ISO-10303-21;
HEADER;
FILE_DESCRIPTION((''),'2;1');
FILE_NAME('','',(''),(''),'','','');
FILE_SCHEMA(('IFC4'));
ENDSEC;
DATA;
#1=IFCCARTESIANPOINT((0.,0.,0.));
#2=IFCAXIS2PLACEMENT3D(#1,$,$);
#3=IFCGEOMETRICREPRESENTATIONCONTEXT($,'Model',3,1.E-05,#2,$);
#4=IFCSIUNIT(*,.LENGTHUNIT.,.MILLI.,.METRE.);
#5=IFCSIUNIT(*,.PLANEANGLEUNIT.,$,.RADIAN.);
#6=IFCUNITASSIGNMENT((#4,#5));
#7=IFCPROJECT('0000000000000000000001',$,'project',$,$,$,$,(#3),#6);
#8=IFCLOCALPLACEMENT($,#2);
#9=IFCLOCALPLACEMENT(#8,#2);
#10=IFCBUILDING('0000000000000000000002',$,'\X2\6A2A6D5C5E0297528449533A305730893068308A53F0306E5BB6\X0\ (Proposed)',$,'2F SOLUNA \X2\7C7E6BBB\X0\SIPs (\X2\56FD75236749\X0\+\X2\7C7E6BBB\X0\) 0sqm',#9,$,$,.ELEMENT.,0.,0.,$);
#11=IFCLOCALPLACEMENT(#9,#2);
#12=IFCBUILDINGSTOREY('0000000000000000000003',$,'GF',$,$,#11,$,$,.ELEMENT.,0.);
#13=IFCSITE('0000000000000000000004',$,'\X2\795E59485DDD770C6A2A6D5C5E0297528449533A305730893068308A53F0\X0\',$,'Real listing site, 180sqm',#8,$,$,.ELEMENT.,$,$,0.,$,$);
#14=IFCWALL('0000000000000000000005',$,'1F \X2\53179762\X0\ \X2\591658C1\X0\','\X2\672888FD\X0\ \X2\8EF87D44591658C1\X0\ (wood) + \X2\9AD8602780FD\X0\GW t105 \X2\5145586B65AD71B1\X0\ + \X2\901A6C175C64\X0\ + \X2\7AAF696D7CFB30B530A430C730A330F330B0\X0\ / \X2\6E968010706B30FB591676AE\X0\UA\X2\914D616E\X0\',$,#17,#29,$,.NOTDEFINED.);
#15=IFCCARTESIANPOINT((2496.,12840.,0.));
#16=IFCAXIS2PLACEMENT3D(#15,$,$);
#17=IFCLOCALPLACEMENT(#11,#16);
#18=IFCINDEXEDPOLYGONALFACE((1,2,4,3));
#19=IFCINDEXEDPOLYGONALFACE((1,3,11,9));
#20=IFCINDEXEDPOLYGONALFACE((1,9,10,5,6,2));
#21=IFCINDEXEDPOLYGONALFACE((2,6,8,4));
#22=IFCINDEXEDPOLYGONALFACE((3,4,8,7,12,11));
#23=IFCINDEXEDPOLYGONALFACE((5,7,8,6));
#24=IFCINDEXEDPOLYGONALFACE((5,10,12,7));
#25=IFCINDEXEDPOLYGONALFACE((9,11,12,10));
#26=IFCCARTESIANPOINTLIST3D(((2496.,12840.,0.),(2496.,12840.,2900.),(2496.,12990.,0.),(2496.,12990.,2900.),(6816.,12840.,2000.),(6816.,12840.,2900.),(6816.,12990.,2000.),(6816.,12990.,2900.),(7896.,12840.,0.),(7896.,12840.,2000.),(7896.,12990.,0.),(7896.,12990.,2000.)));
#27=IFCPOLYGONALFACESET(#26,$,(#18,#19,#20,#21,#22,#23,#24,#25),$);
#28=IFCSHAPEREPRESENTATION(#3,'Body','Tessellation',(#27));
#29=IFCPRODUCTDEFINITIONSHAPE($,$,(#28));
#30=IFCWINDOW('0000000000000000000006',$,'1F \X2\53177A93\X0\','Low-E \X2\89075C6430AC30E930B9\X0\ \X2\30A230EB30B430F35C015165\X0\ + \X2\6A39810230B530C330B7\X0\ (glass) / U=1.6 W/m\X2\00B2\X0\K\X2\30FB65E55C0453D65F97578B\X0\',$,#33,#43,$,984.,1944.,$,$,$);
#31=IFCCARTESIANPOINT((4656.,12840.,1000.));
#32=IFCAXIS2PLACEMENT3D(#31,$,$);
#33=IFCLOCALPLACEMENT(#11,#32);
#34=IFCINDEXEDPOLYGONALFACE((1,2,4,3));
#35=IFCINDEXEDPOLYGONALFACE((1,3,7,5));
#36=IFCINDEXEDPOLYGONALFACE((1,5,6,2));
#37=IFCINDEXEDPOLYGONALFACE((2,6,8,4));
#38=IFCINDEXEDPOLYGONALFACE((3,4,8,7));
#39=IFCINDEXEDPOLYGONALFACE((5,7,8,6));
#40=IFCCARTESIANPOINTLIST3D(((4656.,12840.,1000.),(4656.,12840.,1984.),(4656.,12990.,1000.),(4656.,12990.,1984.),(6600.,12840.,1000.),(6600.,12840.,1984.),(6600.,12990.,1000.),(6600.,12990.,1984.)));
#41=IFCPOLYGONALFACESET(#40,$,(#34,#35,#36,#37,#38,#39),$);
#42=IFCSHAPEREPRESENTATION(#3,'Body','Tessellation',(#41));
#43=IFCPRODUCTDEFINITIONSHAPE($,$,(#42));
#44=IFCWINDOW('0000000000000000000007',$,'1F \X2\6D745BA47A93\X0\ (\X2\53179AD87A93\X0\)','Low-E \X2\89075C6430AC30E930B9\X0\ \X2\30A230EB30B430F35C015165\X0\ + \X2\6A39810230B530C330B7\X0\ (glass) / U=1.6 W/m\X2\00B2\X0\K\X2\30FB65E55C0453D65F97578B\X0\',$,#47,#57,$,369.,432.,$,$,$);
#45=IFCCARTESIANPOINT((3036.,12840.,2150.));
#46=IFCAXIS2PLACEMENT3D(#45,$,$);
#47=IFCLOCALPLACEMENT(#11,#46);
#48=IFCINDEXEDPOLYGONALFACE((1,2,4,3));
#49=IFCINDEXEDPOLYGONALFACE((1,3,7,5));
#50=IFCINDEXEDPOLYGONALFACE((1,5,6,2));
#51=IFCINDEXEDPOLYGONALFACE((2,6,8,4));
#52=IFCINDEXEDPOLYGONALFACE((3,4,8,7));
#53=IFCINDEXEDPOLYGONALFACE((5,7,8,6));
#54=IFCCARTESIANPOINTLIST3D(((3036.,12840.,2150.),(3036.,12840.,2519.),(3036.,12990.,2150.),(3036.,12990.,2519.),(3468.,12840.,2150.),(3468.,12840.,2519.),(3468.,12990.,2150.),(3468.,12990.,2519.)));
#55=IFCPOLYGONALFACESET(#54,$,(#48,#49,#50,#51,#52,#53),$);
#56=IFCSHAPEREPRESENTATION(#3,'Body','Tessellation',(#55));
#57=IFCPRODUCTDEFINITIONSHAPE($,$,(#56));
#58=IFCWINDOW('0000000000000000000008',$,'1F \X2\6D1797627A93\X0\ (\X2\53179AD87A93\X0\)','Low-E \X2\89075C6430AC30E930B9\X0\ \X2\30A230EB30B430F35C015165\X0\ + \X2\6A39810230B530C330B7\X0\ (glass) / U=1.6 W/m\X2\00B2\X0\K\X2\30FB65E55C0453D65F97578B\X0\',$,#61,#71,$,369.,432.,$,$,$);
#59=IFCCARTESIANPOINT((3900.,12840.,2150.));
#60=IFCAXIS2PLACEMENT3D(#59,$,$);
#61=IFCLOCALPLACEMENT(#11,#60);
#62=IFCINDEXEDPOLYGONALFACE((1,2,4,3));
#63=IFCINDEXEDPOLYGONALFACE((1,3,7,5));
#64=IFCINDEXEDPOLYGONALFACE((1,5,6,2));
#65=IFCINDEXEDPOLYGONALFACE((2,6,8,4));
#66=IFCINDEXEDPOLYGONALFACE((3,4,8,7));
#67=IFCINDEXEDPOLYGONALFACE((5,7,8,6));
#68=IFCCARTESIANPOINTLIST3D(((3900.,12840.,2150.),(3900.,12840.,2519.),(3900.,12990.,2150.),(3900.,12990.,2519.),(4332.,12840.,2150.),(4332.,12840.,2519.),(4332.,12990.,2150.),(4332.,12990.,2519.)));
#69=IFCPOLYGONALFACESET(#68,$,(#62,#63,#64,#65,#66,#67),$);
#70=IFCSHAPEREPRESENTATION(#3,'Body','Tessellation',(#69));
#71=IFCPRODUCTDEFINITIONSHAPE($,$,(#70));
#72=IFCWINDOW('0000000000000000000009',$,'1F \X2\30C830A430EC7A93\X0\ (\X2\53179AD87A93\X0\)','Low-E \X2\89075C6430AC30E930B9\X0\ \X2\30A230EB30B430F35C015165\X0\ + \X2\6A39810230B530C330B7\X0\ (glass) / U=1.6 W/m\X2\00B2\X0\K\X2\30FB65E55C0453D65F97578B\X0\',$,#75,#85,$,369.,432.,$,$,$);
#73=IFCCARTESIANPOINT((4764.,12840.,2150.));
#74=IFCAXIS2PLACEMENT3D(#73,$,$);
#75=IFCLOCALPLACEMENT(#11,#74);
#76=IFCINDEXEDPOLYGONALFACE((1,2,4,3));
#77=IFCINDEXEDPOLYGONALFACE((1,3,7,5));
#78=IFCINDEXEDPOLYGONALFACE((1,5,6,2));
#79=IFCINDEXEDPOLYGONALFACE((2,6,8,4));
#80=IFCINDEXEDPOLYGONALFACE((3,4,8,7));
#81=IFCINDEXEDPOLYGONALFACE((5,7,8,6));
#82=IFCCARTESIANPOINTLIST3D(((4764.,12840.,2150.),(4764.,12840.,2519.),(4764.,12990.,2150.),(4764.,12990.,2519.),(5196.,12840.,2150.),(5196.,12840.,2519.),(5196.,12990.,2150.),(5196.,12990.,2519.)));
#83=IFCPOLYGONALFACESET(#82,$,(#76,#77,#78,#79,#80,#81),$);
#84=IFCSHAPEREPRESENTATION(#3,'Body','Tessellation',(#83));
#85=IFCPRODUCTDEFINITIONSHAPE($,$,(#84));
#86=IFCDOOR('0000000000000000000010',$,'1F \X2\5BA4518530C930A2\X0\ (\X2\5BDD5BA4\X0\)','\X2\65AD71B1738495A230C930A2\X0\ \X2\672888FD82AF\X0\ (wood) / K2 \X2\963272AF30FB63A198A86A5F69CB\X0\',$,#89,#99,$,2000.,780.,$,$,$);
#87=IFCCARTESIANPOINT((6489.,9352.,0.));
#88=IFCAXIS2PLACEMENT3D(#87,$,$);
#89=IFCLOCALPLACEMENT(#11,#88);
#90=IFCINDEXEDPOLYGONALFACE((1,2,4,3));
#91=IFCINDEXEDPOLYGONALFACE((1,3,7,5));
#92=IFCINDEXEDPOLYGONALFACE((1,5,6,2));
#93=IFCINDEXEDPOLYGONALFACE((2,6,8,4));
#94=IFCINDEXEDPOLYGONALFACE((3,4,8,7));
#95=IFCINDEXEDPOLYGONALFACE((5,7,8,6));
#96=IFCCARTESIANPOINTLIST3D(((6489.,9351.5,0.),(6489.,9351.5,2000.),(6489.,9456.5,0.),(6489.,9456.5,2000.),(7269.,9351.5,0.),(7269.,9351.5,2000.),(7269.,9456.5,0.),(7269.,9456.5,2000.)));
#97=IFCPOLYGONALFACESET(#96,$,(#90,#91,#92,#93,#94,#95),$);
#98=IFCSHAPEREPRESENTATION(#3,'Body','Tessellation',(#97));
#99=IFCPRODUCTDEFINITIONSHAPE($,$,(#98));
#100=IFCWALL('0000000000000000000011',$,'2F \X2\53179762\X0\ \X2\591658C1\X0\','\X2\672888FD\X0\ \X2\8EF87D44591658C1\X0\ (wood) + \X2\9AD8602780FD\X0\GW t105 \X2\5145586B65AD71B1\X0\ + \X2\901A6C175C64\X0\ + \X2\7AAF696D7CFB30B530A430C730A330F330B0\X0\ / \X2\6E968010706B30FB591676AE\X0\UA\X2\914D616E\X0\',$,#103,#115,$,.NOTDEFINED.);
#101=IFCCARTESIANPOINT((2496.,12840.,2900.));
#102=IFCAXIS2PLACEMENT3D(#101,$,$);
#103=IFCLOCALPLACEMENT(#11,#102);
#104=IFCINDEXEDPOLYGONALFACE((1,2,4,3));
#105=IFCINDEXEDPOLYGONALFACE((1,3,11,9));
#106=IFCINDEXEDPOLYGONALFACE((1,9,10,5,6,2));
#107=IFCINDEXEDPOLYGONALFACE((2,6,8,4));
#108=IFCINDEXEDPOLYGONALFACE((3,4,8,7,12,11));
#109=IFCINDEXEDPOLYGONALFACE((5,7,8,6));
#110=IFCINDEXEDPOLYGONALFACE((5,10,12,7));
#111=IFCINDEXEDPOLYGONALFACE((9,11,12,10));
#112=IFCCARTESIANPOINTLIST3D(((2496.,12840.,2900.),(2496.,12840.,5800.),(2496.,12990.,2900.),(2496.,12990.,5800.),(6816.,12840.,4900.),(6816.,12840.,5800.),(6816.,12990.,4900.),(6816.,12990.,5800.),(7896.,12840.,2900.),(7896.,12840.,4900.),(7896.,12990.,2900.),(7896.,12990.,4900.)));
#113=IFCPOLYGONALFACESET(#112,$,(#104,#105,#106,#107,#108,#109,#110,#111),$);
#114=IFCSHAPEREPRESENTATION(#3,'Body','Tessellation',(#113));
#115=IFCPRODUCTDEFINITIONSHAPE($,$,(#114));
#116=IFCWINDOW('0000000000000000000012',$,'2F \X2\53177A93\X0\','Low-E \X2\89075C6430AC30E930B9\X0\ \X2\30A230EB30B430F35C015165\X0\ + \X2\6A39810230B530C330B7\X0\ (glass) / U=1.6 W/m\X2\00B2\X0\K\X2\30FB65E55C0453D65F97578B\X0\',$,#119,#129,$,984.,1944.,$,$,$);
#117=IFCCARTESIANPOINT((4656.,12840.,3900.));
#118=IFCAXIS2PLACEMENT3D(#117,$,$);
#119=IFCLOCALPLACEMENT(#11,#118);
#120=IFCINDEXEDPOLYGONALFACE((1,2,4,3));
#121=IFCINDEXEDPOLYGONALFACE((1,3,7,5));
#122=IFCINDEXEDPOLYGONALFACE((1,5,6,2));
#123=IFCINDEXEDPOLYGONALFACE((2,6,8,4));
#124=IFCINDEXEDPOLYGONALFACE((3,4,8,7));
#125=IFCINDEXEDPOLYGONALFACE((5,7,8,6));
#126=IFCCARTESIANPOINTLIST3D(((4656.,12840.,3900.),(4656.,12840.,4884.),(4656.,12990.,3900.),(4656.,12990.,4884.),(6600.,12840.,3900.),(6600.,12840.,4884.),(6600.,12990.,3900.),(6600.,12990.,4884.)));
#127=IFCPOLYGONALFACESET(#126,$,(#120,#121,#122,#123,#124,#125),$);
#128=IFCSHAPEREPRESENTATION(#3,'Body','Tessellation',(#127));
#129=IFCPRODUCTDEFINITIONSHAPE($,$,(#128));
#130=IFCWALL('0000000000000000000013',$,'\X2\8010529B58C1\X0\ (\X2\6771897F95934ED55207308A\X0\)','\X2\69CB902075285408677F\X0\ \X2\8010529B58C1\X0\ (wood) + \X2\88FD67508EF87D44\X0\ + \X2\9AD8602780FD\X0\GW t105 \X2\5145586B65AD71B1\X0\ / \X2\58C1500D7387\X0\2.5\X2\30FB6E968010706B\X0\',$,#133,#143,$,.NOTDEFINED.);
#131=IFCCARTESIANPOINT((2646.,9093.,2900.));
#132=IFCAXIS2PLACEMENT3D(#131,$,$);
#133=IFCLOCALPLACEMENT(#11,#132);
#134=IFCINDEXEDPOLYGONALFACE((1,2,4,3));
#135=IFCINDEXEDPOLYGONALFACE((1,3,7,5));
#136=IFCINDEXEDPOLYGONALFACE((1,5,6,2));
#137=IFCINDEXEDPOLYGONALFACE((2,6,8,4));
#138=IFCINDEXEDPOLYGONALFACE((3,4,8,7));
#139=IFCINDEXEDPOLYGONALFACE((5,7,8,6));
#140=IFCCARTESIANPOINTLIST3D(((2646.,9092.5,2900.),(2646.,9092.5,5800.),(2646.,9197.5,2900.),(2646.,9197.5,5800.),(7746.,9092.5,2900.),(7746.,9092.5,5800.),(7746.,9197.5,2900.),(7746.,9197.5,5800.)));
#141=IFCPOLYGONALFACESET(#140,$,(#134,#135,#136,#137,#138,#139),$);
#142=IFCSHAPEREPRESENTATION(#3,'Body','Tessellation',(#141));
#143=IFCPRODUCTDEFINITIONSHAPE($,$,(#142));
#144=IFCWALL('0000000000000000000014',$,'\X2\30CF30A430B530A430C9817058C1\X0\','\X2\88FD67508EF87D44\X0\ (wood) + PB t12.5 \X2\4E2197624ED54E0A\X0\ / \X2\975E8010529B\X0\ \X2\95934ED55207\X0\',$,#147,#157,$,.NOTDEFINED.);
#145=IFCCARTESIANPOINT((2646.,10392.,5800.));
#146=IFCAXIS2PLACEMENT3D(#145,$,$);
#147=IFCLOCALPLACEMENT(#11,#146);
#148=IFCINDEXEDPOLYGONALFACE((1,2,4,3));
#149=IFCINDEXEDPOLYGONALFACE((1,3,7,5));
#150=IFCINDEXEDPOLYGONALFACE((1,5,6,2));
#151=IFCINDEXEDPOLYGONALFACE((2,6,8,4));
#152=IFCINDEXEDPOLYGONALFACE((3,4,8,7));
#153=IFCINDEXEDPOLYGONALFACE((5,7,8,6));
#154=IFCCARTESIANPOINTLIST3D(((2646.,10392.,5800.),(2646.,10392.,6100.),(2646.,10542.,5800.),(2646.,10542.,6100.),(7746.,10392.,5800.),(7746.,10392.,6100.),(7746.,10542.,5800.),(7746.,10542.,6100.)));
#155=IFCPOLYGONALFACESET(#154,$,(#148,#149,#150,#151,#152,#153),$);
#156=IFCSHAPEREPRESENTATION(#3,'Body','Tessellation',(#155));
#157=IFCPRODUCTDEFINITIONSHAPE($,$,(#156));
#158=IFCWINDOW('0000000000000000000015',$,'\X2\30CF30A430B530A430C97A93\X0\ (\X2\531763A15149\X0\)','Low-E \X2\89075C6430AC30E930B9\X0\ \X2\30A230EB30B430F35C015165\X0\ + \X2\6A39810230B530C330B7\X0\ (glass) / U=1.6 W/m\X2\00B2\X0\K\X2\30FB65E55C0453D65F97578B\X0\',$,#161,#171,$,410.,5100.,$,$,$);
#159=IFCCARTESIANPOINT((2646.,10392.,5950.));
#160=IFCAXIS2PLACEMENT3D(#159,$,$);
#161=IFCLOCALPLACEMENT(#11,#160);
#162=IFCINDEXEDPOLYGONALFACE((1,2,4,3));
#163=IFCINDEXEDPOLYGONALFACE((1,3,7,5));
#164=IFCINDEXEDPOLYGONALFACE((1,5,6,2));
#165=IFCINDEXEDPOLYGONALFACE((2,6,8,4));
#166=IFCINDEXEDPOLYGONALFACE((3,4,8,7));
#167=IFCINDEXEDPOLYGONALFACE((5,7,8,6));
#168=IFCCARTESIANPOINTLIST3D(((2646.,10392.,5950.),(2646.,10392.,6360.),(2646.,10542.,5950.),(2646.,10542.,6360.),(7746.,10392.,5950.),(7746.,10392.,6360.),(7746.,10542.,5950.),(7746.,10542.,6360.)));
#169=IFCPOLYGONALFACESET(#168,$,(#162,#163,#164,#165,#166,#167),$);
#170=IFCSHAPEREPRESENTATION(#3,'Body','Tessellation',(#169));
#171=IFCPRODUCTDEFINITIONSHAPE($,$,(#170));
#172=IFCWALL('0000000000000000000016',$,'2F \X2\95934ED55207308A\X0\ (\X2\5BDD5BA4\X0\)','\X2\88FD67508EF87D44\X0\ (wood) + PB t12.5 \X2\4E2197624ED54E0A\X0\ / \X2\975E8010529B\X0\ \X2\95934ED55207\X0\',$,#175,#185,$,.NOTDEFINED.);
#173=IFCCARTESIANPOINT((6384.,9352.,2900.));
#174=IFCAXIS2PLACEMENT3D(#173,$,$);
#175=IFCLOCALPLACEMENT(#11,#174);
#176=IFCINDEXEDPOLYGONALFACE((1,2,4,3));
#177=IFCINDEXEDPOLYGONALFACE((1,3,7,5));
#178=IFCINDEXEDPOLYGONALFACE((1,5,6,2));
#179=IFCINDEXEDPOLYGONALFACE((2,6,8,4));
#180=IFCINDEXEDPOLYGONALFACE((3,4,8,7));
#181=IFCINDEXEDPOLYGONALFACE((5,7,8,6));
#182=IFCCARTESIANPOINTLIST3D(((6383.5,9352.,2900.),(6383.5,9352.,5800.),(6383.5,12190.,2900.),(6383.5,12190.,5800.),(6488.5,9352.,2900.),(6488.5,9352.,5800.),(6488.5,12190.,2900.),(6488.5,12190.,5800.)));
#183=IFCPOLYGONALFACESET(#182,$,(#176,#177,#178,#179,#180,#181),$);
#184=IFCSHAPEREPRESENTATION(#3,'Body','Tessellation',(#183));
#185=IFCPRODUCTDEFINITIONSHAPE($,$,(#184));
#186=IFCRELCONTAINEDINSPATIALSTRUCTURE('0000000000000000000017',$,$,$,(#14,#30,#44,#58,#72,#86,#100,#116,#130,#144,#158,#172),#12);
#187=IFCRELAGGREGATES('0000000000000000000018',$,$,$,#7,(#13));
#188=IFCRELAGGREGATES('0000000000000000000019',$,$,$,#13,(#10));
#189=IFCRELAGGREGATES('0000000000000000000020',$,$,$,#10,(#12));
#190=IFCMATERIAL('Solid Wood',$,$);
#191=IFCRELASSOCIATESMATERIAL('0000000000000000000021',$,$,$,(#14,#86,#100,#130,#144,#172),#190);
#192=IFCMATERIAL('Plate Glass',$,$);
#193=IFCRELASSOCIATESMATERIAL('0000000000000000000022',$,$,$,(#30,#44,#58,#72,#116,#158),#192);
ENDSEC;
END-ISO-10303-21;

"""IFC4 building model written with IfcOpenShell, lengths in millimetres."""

from ifc_helpers import new_model, si_unit, frame, frame_2d, origin, place, context, project, spatial, rectangle, extrude, material, element, fill, save


model = new_model("IFC4")

# Units and contexts
model_context = context("Model", 3, precision=1e-05, world=origin())
ifc_project = project(units=[si_unit("LENGTHUNIT", "METRE", prefix="MILLI"), si_unit("PLANEANGLEUNIT", "RADIAN")], contexts=[model_context])

# Site, building, storey
site_placement = place(None, origin())
site = spatial("IfcSite", under=ifc_project, at=site_placement, Name="神奈川県横浜市青葉区しらとり台", ObjectType="Real listing site, 180sqm", CompositionType="ELEMENT", RefElevation=0.0)
building_placement = place(site_placement, origin())
building = spatial("IfcBuilding", under=site, at=building_placement, Name="横浜市青葉区しらとり台の家 (Proposed)", ObjectType="2F SOLUNA 籾殻SIPs (国産杉+籾殻) 0sqm", CompositionType="ELEMENT", ElevationOfRefHeight=0.0, ElevationOfTerrain=0.0)
storey_placement = place(building_placement, origin())
storey = spatial("IfcBuildingStorey", under=building, at=storey_placement, Name="GF", CompositionType="ELEMENT", Elevation=0.0)

# Wall, openings, windows
ifc_material_1 = material(Name="Solid Wood")
wall_1_placement = place(storey_placement, frame((2496.0, 12840.0, 0.0)))
wall_1 = element("IfcWall", 1, at=wall_1_placement, inside=storey, material=ifc_material_1, Name="1F 北面 外壁", Description="木製 軸組外壁 (wood) + 高性能GW t105 充填断熱 + 通気層 + 窯業系サイディング / 準耐火・外皮UA配慮", PredefinedType="NOTDEFINED", context=model_context, shape_type="SweptSolid", body=[
    extrude(rectangle(XDim=5400.0, YDim=150.0, at=frame_2d((2700.0, 75.0))), frame((2496.0, 12840.0, 0.0)), (0.0, 0.0, 1.0), 2900.0),
])
opening_1_placement = place(storey_placement, frame((4656.0, 12840.0, 1000.0)))
opening_1 = element("IfcOpeningElement", 2, at=opening_1_placement, cuts=wall_1, PredefinedType="NOTDEFINED", context=model_context, shape_type="SweptSolid", body=[
    extrude(rectangle(XDim=1944.0, YDim=150.0, at=frame_2d((972.0, 75.0))), frame((4656.0, 12840.0, 1000.0)), (0.0, 0.0, 1.0), 984.0),
])
opening_2_placement = place(storey_placement, frame((3036.0, 12840.0, 2150.0)))
opening_2 = element("IfcOpeningElement", 3, at=opening_2_placement, cuts=wall_1, PredefinedType="NOTDEFINED", context=model_context, shape_type="SweptSolid", body=[
    extrude(rectangle(XDim=432.0, YDim=150.0, at=frame_2d((216.0, 75.0))), frame((3036.0, 12840.0, 2150.0)), (0.0, 0.0, 1.0), 369.0),
])
opening_3_placement = place(storey_placement, frame((3900.0, 12840.0, 2150.0)))
opening_3 = element("IfcOpeningElement", 4, at=opening_3_placement, cuts=wall_1, PredefinedType="NOTDEFINED", context=model_context, shape_type="SweptSolid", body=[
    extrude(rectangle(XDim=432.0, YDim=150.0, at=frame_2d((216.0, 75.0))), frame((3900.0, 12840.0, 2150.0)), (0.0, 0.0, 1.0), 369.0),
])
opening_4_placement = place(storey_placement, frame((4764.0, 12840.0, 2150.0)))
opening_4 = element("IfcOpeningElement", 5, at=opening_4_placement, cuts=wall_1, PredefinedType="NOTDEFINED", context=model_context, shape_type="SweptSolid", body=[
    extrude(rectangle(XDim=432.0, YDim=150.0, at=frame_2d((216.0, 75.0))), frame((4764.0, 12840.0, 2150.0)), (0.0, 0.0, 1.0), 369.0),
])
ifc_material_2 = material(Name="Plate Glass")
window_1_placement = place(storey_placement, frame((4656.0, 12840.0, 1000.0)))
window_1 = element("IfcWindow", 6, at=window_1_placement, inside=storey, material=ifc_material_2, Name="1F 北窓", Description="Low-E 複層ガラス アルゴン封入 + 樹脂サッシ (glass) / U=1.6 W/m²K・日射取得型", OverallHeight=984.0, OverallWidth=1944.0, context=model_context, shape_type="SweptSolid", body=[
    extrude(rectangle(XDim=1944.0, YDim=150.0, at=frame_2d((972.0, 75.0))), frame((4656.0, 12840.0, 1000.0)), (0.0, 0.0, 1.0), 984.0),
])
fill(opening_1, window_1)
window_2_placement = place(storey_placement, frame((3036.0, 12840.0, 2150.0)))
window_2 = element("IfcWindow", 7, at=window_2_placement, inside=storey, material=ifc_material_2, Name="1F 浴室窓 (北高窓)", Description="Low-E 複層ガラス アルゴン封入 + 樹脂サッシ (glass) / U=1.6 W/m²K・日射取得型", OverallHeight=369.0, OverallWidth=432.0, context=model_context, shape_type="SweptSolid", body=[
    extrude(rectangle(XDim=432.0, YDim=150.0, at=frame_2d((216.0, 75.0))), frame((3036.0, 12840.0, 2150.0)), (0.0, 0.0, 1.0), 369.0),
])
fill(opening_2, window_2)
window_3_placement = place(storey_placement, frame((3900.0, 12840.0, 2150.0)))
window_3 = element("IfcWindow", 8, at=window_3_placement, inside=storey, material=ifc_material_2, Name="1F 洗面窓 (北高窓)", Description="Low-E 複層ガラス アルゴン封入 + 樹脂サッシ (glass) / U=1.6 W/m²K・日射取得型", OverallHeight=369.0, OverallWidth=432.0, context=model_context, shape_type="SweptSolid", body=[
    extrude(rectangle(XDim=432.0, YDim=150.0, at=frame_2d((216.0, 75.0))), frame((3900.0, 12840.0, 2150.0)), (0.0, 0.0, 1.0), 369.0),
])
fill(opening_3, window_3)
window_4_placement = place(storey_placement, frame((4764.0, 12840.0, 2150.0)))
window_4 = element("IfcWindow", 9, at=window_4_placement, inside=storey, material=ifc_material_2, Name="1F トイレ窓 (北高窓)", Description="Low-E 複層ガラス アルゴン封入 + 樹脂サッシ (glass) / U=1.6 W/m²K・日射取得型", OverallHeight=369.0, OverallWidth=432.0, context=model_context, shape_type="SweptSolid", body=[
    extrude(rectangle(XDim=432.0, YDim=150.0, at=frame_2d((216.0, 75.0))), frame((4764.0, 12840.0, 2150.0)), (0.0, 0.0, 1.0), 369.0),
])
fill(opening_4, window_4)

# Door
door_1_placement = place(storey_placement, frame((6489.0, 9352.0, 0.0)))
element("IfcDoor", 10, at=door_1_placement, inside=storey, material=ifc_material_1, Name="1F 室内ドア (寝室)", Description="断熱玄関ドア 木製芯 (wood) / K2 防犯・採風機構", OverallHeight=2000.0, OverallWidth=780.0, context=model_context, shape_type="SweptSolid", body=[
    extrude(rectangle(XDim=780.0, YDim=105.0, at=frame_2d((390.0, 52.0))), frame((6489.0, 9352.0, 0.0)), (0.0, 0.0, 1.0), 2000.0),
])

# Wall, opening, window
wall_2_placement = place(storey_placement, frame((2496.0, 12840.0, 2900.0)))
wall_2 = element("IfcWall", 11, at=wall_2_placement, inside=storey, material=ifc_material_1, Name="2F 北面 外壁", Description="木製 軸組外壁 (wood) + 高性能GW t105 充填断熱 + 通気層 + 窯業系サイディング / 準耐火・外皮UA配慮", PredefinedType="NOTDEFINED", context=model_context, shape_type="SweptSolid", body=[
    extrude(rectangle(XDim=5400.0, YDim=150.0, at=frame_2d((2700.0, 75.0))), frame((2496.0, 12840.0, 2900.0)), (0.0, 0.0, 1.0), 2900.0),
])
opening_5_placement = place(storey_placement, frame((4656.0, 12840.0, 3900.0)))
opening_5 = element("IfcOpeningElement", 12, at=opening_5_placement, cuts=wall_2, PredefinedType="NOTDEFINED", context=model_context, shape_type="SweptSolid", body=[
    extrude(rectangle(XDim=1944.0, YDim=150.0, at=frame_2d((972.0, 75.0))), frame((4656.0, 12840.0, 3900.0)), (0.0, 0.0, 1.0), 984.0),
])
window_5_placement = place(storey_placement, frame((4656.0, 12840.0, 3900.0)))
window_5 = element("IfcWindow", 13, at=window_5_placement, inside=storey, material=ifc_material_2, Name="2F 北窓", Description="Low-E 複層ガラス アルゴン封入 + 樹脂サッシ (glass) / U=1.6 W/m²K・日射取得型", OverallHeight=984.0, OverallWidth=1944.0, context=model_context, shape_type="SweptSolid", body=[
    extrude(rectangle(XDim=1944.0, YDim=150.0, at=frame_2d((972.0, 75.0))), frame((4656.0, 12840.0, 3900.0)), (0.0, 0.0, 1.0), 984.0),
])
fill(opening_5, window_5)

# Wall
wall_3_placement = place(storey_placement, frame((2646.0, 9093.0, 2900.0)))
element("IfcWall", 14, at=wall_3_placement, inside=storey, material=ifc_material_1, Name="耐力壁 (東西間仕切り)", Description="構造用合板 耐力壁 (wood) + 製材軸組 + 高性能GW t105 充填断熱 / 壁倍率2.5・準耐火", PredefinedType="NOTDEFINED", context=model_context, shape_type="SweptSolid", body=[
    extrude(rectangle(XDim=5100.0, YDim=105.0, at=frame_2d((2550.0, 52.0))), frame((2646.0, 9093.0, 2900.0)), (0.0, 0.0, 1.0), 2900.0),
])

# Wall, opening, window
wall_4_placement = place(storey_placement, frame((2646.0, 10392.0, 5800.0)))
wall_4 = element("IfcWall", 15, at=wall_4_placement, inside=storey, material=ifc_material_1, Name="ハイサイド腰壁", Description="製材軸組 (wood) + PB t12.5 両面仕上 / 非耐力 間仕切", PredefinedType="NOTDEFINED", context=model_context, shape_type="SweptSolid", body=[
    extrude(rectangle(XDim=5100.0, YDim=150.0, at=frame_2d((2550.0, 75.0))), frame((2646.0, 10392.0, 5800.0)), (0.0, 0.0, 1.0), 700.0),
])
opening_6_placement = place(storey_placement, frame((2646.0, 10392.0, 5950.0)))
opening_6 = element("IfcOpeningElement", 16, at=opening_6_placement, cuts=wall_4, PredefinedType="NOTDEFINED", context=model_context, shape_type="SweptSolid", body=[
    extrude(rectangle(XDim=5100.0, YDim=150.0, at=frame_2d((2550.0, 75.0))), frame((2646.0, 10392.0, 5950.0)), (0.0, 0.0, 1.0), 410.0),
])
window_6_placement = place(storey_placement, frame((2646.0, 10392.0, 5950.0)))
window_6 = element("IfcWindow", 17, at=window_6_placement, inside=storey, material=ifc_material_2, Name="ハイサイド窓 (北採光)", Description="Low-E 複層ガラス アルゴン封入 + 樹脂サッシ (glass) / U=1.6 W/m²K・日射取得型", OverallHeight=410.0, OverallWidth=5100.0, context=model_context, shape_type="SweptSolid", body=[
    extrude(rectangle(XDim=5100.0, YDim=150.0, at=frame_2d((2550.0, 75.0))), frame((2646.0, 10392.0, 5950.0)), (0.0, 0.0, 1.0), 410.0),
])
fill(opening_6, window_6)

# Wall
wall_5_placement = place(storey_placement, frame((6384.0, 9352.0, 2900.0)))
element("IfcWall", 18, at=wall_5_placement, inside=storey, material=ifc_material_1, Name="2F 間仕切り (寝室)", Description="製材軸組 (wood) + PB t12.5 両面仕上 / 非耐力 間仕切", PredefinedType="NOTDEFINED", context=model_context, shape_type="SweptSolid", body=[
    extrude(rectangle(XDim=105.0, YDim=2838.0, at=frame_2d((52.0, 1419.0))), frame((6384.0, 9352.0, 2900.0)), (0.0, 0.0, 1.0), 2900.0),
])

save(model, "model.ifc")
